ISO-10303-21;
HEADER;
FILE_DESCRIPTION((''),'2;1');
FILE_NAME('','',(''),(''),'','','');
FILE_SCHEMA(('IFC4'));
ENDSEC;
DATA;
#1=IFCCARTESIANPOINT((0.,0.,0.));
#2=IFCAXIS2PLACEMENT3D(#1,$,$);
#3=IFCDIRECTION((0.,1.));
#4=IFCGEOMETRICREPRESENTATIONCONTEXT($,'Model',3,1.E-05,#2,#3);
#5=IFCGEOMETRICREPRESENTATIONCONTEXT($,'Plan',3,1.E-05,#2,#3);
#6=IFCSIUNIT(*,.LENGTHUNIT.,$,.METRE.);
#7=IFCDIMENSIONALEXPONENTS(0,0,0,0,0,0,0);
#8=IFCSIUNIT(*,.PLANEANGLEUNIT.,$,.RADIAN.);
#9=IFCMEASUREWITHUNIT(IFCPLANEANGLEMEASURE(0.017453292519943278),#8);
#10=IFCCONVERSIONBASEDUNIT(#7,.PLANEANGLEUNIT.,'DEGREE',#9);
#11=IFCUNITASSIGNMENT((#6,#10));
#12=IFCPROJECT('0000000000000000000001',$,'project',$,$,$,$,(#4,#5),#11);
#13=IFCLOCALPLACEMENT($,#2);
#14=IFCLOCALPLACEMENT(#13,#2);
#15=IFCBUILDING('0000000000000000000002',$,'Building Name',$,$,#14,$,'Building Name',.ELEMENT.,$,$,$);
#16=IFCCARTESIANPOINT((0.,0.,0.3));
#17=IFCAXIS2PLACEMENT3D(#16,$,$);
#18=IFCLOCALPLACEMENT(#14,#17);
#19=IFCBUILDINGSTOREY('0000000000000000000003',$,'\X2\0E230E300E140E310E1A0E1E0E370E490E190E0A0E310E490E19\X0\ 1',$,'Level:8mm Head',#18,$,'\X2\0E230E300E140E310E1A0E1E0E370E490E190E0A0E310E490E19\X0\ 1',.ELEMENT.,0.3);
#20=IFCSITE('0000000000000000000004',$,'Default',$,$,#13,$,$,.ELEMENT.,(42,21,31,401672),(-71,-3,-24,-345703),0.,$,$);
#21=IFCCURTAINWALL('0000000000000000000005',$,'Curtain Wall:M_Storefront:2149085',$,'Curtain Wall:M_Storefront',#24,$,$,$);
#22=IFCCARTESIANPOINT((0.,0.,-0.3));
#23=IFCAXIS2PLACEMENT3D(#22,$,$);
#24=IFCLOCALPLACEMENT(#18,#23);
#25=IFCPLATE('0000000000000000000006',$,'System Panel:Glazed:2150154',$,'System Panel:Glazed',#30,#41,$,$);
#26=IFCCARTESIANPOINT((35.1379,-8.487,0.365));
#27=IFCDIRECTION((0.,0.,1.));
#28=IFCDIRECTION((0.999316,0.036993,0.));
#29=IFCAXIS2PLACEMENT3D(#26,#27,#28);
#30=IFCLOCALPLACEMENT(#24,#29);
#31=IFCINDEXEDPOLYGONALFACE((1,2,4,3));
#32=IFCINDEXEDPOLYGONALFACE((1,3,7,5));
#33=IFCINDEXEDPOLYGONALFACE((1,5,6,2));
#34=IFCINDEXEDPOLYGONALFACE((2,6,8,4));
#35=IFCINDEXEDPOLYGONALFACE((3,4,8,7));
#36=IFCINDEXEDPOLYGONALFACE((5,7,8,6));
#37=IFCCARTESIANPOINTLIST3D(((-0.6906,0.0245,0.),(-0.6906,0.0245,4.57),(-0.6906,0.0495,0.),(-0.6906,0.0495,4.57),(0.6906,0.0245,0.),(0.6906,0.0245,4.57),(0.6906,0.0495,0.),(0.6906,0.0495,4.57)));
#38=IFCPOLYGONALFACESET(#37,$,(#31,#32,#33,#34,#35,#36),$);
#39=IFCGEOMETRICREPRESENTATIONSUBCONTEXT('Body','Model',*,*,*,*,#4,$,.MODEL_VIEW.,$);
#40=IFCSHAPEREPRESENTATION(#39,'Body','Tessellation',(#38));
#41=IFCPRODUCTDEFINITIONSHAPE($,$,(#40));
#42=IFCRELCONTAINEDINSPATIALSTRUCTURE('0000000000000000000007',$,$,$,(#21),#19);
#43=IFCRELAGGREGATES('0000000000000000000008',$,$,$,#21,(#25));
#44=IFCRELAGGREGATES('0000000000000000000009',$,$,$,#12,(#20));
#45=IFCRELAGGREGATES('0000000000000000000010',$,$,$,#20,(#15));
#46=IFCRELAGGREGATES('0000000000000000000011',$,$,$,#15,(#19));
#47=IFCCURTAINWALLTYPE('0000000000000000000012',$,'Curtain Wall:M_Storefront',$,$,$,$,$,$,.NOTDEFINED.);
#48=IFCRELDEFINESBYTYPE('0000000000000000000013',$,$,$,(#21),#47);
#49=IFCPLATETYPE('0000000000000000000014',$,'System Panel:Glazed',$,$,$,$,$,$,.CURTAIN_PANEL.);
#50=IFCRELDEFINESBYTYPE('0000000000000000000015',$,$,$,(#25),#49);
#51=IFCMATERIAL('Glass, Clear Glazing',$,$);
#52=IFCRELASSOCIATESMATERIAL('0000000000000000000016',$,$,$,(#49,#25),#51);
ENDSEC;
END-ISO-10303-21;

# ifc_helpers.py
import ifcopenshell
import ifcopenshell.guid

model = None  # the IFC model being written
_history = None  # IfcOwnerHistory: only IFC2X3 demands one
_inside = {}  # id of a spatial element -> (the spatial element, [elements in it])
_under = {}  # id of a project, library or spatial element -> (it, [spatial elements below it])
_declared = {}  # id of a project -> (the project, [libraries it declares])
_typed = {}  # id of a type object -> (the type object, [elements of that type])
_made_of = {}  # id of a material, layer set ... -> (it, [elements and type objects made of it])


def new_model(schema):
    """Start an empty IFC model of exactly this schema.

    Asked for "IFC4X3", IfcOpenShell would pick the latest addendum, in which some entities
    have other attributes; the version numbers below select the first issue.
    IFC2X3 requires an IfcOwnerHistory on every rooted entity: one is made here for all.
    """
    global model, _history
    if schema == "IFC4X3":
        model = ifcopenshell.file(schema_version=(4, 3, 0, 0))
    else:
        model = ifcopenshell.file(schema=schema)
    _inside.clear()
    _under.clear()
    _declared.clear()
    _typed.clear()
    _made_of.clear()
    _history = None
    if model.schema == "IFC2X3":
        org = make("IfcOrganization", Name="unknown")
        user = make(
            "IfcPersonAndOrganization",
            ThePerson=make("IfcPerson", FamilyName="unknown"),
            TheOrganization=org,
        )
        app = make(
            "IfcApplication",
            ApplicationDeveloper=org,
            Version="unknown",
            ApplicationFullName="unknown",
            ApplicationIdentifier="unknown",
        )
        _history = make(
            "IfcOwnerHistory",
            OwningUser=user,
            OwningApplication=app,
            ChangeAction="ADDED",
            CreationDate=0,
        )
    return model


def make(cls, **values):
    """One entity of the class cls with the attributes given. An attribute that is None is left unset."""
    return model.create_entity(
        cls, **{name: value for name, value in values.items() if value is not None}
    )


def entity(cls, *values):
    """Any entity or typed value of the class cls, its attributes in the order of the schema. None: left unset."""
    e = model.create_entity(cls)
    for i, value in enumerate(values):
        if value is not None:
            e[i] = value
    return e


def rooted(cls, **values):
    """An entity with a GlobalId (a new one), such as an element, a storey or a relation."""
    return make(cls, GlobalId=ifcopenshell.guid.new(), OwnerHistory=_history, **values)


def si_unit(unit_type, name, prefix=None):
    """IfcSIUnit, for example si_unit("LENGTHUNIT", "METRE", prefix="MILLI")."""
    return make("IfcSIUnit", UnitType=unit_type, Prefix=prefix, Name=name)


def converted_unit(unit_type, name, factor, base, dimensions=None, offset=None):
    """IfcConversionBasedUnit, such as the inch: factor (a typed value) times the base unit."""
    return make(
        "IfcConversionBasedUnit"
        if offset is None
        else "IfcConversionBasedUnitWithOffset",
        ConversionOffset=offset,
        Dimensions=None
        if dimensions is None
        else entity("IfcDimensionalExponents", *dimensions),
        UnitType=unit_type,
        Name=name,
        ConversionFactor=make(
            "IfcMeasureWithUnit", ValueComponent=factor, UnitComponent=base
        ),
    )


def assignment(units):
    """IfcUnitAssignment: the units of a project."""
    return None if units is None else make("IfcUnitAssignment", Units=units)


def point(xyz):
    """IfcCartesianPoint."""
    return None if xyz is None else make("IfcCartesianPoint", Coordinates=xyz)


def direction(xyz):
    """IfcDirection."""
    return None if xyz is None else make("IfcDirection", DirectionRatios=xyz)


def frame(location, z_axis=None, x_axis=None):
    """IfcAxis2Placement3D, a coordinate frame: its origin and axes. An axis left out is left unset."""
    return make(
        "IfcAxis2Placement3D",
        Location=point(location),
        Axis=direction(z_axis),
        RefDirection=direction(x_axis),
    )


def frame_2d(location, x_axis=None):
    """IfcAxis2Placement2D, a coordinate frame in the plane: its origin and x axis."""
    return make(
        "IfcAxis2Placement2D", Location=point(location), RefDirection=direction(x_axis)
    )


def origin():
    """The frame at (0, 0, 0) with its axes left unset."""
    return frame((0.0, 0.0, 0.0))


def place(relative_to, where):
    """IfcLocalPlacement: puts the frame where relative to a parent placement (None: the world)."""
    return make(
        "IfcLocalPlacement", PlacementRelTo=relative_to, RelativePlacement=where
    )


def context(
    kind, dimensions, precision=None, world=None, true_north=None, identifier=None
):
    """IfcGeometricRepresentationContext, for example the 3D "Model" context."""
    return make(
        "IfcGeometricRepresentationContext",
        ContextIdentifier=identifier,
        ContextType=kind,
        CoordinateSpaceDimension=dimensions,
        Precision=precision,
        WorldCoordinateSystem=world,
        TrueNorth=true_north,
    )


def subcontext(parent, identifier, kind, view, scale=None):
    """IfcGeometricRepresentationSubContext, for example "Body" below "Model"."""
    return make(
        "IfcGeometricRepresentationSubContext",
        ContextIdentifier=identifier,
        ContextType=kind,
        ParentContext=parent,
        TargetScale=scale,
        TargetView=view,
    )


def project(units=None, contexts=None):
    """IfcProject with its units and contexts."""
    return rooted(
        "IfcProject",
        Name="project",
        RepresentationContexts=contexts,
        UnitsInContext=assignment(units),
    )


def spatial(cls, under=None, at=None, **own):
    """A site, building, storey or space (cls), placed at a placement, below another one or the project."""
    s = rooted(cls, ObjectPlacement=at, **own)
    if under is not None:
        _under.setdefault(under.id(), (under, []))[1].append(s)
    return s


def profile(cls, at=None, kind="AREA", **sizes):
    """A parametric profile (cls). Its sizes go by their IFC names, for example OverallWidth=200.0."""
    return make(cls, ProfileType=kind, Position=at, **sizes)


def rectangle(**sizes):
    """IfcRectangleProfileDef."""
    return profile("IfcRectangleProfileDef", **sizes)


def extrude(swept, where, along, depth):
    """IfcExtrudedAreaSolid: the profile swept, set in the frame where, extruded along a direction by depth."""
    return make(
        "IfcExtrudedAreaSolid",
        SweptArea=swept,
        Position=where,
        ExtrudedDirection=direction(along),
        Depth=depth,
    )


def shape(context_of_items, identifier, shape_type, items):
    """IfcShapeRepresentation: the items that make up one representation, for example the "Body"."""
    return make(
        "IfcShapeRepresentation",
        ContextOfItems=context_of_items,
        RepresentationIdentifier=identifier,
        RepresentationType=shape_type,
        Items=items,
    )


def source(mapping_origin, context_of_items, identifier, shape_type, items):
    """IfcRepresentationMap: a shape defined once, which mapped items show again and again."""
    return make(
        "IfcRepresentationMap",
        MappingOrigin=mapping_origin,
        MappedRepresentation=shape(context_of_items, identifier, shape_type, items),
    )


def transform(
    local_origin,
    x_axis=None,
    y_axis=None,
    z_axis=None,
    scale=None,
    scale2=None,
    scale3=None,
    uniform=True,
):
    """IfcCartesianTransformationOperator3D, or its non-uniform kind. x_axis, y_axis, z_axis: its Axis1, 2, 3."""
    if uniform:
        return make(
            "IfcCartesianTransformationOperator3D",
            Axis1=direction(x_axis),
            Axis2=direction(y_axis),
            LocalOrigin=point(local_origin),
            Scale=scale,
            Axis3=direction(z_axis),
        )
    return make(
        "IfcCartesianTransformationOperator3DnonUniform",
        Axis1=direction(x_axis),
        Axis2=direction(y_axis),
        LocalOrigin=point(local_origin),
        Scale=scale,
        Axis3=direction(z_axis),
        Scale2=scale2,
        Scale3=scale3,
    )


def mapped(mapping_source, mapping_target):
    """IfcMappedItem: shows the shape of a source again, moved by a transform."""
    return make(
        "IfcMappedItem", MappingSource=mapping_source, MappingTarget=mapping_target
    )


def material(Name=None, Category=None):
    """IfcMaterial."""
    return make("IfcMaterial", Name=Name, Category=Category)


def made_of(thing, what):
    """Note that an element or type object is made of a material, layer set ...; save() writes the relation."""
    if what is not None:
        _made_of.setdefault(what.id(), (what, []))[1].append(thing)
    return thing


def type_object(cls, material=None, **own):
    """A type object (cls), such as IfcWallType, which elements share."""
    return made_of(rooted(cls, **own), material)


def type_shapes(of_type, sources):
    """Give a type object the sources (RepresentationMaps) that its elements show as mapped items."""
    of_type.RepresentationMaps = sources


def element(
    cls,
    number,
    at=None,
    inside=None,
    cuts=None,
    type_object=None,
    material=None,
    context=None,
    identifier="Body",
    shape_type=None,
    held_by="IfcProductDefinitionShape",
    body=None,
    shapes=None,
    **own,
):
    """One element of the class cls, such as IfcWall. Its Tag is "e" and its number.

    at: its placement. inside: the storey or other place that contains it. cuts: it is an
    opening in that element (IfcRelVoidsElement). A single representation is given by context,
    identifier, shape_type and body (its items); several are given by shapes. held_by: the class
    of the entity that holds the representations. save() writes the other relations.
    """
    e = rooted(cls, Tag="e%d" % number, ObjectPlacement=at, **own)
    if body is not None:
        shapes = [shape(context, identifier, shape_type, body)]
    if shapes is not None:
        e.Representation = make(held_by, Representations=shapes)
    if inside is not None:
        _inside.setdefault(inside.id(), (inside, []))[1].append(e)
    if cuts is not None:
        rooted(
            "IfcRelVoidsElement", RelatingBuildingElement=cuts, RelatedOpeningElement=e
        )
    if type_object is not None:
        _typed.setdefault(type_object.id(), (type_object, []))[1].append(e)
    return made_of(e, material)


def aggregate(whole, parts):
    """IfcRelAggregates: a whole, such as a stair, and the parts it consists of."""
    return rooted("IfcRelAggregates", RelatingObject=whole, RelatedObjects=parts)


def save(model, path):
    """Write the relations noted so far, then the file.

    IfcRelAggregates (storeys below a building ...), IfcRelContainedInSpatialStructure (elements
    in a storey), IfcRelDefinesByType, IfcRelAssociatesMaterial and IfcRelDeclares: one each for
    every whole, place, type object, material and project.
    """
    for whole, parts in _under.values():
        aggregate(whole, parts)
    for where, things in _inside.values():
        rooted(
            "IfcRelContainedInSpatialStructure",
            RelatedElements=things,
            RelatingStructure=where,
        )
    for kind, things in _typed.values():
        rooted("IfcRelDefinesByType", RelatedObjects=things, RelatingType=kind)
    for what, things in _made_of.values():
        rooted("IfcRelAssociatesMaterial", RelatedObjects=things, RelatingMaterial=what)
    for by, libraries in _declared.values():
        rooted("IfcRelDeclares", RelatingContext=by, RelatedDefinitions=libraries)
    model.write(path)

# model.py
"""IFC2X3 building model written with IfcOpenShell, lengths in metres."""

from ifc_helpers import new_model, entity, si_unit, converted_unit, direction, frame, frame_2d, origin, place, context, subcontext, project, spatial, rectangle, extrude, source, transform, mapped, material, type_object, type_shapes, element, aggregate, save


model = new_model("IFC2X3")

# Units and contexts
model_context = context("Model", 3, precision=1e-05, world=origin(), true_north=direction((0.0, 1.0)))
plan_context = context("Plan", 3, precision=1e-05, world=origin(), true_north=direction((0.0, 1.0)))
body_context = subcontext(model_context, "Body", "Model", "MODEL_VIEW")
ifc_project = project(units=[si_unit("LENGTHUNIT", "METRE"), converted_unit("PLANEANGLEUNIT", "DEGREE", entity("IfcPlaneAngleMeasure", 0.017453292519943278), si_unit("PLANEANGLEUNIT", "RADIAN"), dimensions=[0, 0, 0, 0, 0, 0, 0])], contexts=[model_context, plan_context])

# Site, building, storey
site_placement = place(None, origin())
site = spatial("IfcSite", under=ifc_project, at=site_placement, Name="Default", CompositionType="ELEMENT", RefLatitude=(42, 21, 31, 401672), RefLongitude=(-71, -3, -24, -345703), RefElevation=0.0)
building_placement = place(site_placement, origin())
building = spatial("IfcBuilding", under=site, at=building_placement, Name="Building Name", LongName="Building Name", CompositionType="ELEMENT")
storey_placement = place(building_placement, frame((0.0, 0.0, 0.3)))
storey = spatial("IfcBuildingStorey", under=building, at=storey_placement, Name="ระดับพื้นชั้น 1", ObjectType="Level:8mm Head", LongName="ระดับพื้นชั้น 1", CompositionType="ELEMENT", Elevation=0.3)

# Curtain wall, plate
curtain_wall_type = type_object("IfcCurtainWallType", Name="Curtain Wall:M_Storefront", PredefinedType="NOTDEFINED")
curtain_wall_placement = place(storey_placement, frame((0.0, 0.0, -0.3)))
curtain_wall = element("IfcCurtainWall", 1, at=curtain_wall_placement, inside=storey, type_object=curtain_wall_type, Name="Curtain Wall:M_Storefront:2149085", ObjectType="Curtain Wall:M_Storefront")
ifc_material_1 = material(Name="Glass, Clear Glazing")
plate_type = type_object("IfcPlateType", Name="System Panel:Glazed", PredefinedType="CURTAIN_PANEL", material=ifc_material_1)
shared_shape_1 = source(origin(), body_context, "Body", "SweptSolid", [
    extrude(rectangle(XDim=0.025, YDim=1.3812, at=frame_2d((0.0, 0.0), x_axis=(1.0, 0.0))), frame((0.0, 0.037, 0.0), z_axis=(0.0, 0.0, 1.0), x_axis=(0.0, 1.0, 0.0)), (0.0, 0.0, 1.0), 4.57),
])
type_shapes(plate_type, [shared_shape_1])
plate_placement = place(curtain_wall_placement, frame((35.1379, -8.487, 0.365), z_axis=(0.0, 0.0, 1.0), x_axis=(0.999316, 0.036993, 0.0)))
plate = element("IfcPlate", 2, at=plate_placement, type_object=plate_type, material=ifc_material_1, Name="System Panel:Glazed:2150154", ObjectType="System Panel:Glazed", context=body_context, shape_type="MappedRepresentation", body=[
    mapped(shared_shape_1, transform((0.0, 0.0, 0.0), scale=1.0)),
])
aggregate(curtain_wall, [plate])

save(model, "model.ifc")
